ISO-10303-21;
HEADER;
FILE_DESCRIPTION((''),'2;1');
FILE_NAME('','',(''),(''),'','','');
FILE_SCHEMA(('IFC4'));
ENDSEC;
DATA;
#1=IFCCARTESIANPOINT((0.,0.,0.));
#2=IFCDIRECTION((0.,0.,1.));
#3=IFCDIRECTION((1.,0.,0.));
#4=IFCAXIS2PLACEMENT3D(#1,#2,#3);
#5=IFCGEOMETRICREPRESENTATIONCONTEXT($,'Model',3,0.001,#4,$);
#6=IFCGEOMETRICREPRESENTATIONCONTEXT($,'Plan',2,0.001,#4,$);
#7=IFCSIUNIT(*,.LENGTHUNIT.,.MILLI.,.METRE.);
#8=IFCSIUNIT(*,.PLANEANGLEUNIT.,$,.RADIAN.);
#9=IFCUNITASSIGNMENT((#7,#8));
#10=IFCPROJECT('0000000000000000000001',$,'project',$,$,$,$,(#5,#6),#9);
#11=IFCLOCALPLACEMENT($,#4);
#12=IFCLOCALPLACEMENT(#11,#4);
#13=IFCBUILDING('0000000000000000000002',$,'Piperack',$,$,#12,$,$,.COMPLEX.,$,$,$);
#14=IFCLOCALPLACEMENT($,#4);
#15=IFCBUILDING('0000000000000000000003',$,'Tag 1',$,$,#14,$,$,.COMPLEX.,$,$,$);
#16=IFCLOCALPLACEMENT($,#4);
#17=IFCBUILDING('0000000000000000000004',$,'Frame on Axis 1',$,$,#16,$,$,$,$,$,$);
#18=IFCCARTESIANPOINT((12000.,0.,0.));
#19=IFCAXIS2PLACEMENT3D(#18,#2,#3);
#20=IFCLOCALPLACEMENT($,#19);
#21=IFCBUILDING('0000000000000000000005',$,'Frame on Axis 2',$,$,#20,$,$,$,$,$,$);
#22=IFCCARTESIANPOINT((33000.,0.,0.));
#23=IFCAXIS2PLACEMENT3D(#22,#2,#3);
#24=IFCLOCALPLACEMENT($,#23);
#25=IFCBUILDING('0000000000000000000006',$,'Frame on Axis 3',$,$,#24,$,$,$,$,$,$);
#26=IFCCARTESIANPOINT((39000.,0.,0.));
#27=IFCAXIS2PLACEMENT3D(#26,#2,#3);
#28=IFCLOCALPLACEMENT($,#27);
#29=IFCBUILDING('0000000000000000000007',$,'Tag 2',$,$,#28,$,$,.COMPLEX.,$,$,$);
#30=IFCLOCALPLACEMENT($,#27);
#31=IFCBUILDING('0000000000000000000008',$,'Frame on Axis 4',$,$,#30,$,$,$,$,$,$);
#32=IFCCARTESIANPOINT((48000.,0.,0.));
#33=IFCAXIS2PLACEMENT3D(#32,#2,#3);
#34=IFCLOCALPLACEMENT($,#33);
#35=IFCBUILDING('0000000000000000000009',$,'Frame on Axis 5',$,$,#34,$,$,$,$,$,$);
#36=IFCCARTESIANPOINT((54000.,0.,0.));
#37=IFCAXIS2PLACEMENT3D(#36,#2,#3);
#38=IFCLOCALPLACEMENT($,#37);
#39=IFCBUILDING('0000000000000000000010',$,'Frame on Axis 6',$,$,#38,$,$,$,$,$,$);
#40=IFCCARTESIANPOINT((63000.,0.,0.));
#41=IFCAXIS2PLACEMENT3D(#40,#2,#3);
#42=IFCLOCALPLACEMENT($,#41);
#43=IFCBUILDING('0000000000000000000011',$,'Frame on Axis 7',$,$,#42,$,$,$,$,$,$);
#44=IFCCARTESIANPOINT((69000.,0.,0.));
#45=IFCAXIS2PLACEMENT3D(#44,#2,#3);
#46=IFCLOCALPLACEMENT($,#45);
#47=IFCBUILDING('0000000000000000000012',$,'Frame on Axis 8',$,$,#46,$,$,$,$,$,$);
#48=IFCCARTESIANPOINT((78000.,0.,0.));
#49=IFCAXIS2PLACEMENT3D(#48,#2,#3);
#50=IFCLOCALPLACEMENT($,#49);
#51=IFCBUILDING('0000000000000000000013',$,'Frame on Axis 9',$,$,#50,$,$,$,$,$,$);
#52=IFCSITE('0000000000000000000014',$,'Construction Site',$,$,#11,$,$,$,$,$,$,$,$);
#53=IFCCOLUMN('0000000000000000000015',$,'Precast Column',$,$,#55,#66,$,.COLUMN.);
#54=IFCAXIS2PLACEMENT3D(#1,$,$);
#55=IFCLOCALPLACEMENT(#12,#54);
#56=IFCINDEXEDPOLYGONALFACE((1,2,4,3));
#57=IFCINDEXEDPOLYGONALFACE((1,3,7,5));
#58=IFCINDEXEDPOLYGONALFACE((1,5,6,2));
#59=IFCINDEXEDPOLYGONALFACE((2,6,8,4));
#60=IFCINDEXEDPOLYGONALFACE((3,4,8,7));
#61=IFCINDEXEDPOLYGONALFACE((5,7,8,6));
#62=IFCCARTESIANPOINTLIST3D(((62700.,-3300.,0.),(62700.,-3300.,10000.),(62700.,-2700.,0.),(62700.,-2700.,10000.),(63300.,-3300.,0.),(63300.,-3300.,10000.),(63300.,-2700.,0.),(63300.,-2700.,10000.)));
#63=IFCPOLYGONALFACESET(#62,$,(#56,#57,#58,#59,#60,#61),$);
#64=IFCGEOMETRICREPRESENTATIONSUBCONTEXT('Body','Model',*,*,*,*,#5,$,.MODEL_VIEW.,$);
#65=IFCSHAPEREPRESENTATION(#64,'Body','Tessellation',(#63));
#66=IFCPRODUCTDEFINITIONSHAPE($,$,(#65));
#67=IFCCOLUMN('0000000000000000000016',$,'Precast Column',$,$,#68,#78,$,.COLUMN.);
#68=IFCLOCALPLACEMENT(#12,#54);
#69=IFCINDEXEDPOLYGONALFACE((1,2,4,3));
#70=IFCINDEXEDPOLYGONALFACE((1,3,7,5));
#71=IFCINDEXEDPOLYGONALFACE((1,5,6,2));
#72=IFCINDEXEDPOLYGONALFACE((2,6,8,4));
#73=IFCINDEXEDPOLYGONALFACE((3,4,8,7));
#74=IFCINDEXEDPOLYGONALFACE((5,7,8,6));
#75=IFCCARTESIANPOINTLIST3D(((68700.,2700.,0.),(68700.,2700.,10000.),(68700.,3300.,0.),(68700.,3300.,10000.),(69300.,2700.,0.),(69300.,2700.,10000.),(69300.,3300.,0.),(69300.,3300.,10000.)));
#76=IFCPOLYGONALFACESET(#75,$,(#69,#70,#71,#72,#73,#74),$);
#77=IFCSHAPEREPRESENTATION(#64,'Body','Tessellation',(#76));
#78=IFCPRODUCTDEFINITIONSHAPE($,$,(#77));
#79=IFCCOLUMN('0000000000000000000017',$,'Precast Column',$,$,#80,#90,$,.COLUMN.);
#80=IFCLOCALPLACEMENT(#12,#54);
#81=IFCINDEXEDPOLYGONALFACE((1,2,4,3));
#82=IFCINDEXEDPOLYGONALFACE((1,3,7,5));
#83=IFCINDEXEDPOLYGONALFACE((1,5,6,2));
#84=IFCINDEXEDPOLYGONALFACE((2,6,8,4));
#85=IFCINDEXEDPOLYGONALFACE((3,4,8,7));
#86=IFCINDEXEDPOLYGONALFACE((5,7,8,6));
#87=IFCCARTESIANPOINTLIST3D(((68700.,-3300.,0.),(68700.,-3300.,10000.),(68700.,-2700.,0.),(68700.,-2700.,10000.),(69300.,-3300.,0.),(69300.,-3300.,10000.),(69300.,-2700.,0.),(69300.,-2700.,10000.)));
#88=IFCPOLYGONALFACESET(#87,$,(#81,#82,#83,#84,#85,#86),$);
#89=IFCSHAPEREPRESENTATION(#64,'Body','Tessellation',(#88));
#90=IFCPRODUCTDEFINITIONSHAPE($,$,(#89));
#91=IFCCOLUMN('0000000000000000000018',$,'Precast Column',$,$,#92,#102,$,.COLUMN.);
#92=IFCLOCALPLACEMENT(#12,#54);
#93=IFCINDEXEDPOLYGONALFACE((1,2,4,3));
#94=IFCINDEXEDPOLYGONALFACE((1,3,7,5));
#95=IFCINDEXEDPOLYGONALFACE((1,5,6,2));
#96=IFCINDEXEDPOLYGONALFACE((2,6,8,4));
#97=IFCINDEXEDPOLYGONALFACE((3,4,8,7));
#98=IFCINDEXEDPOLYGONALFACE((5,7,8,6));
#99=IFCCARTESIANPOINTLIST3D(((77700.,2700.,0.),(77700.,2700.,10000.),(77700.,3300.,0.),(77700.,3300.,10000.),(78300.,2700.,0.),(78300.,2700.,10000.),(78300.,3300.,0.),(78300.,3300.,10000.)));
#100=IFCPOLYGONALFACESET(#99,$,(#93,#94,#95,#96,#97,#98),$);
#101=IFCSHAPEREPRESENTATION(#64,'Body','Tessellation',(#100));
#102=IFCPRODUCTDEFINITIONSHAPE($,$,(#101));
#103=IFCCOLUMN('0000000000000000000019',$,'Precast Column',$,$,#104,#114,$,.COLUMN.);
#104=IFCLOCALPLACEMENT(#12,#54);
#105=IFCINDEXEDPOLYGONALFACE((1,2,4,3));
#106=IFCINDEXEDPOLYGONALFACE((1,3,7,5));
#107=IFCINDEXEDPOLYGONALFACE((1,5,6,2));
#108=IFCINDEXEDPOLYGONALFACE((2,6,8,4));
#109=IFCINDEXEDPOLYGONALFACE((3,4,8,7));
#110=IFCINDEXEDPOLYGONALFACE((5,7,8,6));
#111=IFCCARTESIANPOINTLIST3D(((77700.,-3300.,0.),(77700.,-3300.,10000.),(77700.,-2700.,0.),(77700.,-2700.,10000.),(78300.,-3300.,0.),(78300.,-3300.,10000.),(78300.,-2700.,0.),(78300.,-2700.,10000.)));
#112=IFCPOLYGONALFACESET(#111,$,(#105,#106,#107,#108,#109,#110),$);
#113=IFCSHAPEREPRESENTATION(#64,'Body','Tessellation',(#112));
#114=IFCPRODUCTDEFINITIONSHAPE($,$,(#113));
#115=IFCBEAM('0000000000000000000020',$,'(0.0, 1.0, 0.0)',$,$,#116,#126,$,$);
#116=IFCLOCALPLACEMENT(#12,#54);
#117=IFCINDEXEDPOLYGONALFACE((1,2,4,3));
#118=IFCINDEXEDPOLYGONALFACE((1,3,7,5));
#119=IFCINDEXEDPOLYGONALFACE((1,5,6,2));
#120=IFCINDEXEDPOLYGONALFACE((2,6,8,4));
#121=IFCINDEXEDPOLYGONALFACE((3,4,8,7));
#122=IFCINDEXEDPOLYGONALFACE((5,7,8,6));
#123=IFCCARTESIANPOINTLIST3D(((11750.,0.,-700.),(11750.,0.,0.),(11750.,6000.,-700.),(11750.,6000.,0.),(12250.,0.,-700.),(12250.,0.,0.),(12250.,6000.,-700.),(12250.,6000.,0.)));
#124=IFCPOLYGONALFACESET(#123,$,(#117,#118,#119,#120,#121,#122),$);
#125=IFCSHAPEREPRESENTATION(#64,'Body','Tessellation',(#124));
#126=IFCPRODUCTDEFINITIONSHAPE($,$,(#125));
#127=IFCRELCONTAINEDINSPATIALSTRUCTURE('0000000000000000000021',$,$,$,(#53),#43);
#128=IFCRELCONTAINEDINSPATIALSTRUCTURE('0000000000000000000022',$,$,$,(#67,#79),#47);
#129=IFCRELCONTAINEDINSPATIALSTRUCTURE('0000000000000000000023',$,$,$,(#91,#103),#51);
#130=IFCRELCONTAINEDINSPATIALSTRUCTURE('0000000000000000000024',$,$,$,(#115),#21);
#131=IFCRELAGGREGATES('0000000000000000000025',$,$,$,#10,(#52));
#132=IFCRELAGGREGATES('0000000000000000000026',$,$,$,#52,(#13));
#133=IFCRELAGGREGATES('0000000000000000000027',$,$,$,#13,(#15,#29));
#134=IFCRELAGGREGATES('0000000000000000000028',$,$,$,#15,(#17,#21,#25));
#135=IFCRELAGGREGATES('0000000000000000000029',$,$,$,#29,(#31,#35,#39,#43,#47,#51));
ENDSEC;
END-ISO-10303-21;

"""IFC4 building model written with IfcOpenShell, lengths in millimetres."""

from ifc_helpers import new_model, si_unit, frame, origin, origin_with_axes, place, context, subcontext, project, spatial, rectangle, extrude, element, save


model = new_model("IFC4")

# Units and contexts
model_context = context("Model", 3, precision=0.001, world=origin_with_axes())
plan_context = context("Plan", 2, precision=0.001, world=origin_with_axes())
body_context = subcontext(model_context, "Body", "Model", "MODEL_VIEW")
ifc_project = project(units=[si_unit("LENGTHUNIT", "METRE", prefix="MILLI"), si_unit("PLANEANGLEUNIT", "RADIAN")], contexts=[model_context, plan_context])

# Site, buildings
site_placement = place(None, origin_with_axes())
site = spatial("IfcSite", under=ifc_project, at=site_placement, Name="Construction Site")
building_1_placement = place(site_placement, origin_with_axes())
building_1 = spatial("IfcBuilding", under=site, at=building_1_placement, Name="Piperack", CompositionType="COMPLEX")
building_2_placement = place(None, origin_with_axes())
building_2 = spatial("IfcBuilding", under=building_1, at=building_2_placement, Name="Tag 1", CompositionType="COMPLEX")
building_3_placement = place(None, origin_with_axes())
building_3 = spatial("IfcBuilding", under=building_2, at=building_3_placement, Name="Frame on Axis 1")

# Shared definitions
building_4_placement = place(None, frame((12000.0, 0.0, 0.0), z_axis=(0.0, 0.0, 1.0), x_axis=(1.0, 0.0, 0.0)))
building_4 = spatial("IfcBuilding", under=building_2, at=building_4_placement, Name="Frame on Axis 2")

# Shared definitions
building_5_placement = place(None, frame((33000.0, 0.0, 0.0), z_axis=(0.0, 0.0, 1.0), x_axis=(1.0, 0.0, 0.0)))
building_5 = spatial("IfcBuilding", under=building_2, at=building_5_placement, Name="Frame on Axis 3")

# Shared definitions
building_6_placement = place(None, frame((39000.0, 0.0, 0.0), z_axis=(0.0, 0.0, 1.0), x_axis=(1.0, 0.0, 0.0)))
building_6 = spatial("IfcBuilding", under=building_1, at=building_6_placement, Name="Tag 2", CompositionType="COMPLEX")
building_7_placement = place(None, frame((39000.0, 0.0, 0.0), z_axis=(0.0, 0.0, 1.0), x_axis=(1.0, 0.0, 0.0)))
building_7 = spatial("IfcBuilding", under=building_6, at=building_7_placement, Name="Frame on Axis 4")

# Shared definitions
building_8_placement = place(None, frame((48000.0, 0.0, 0.0), z_axis=(0.0, 0.0, 1.0), x_axis=(1.0, 0.0, 0.0)))
building_8 = spatial("IfcBuilding", under=building_6, at=building_8_placement, Name="Frame on Axis 5")

# Shared definitions
building_9_placement = place(None, frame((54000.0, 0.0, 0.0), z_axis=(0.0, 0.0, 1.0), x_axis=(1.0, 0.0, 0.0)))
building_9 = spatial("IfcBuilding", under=building_6, at=building_9_placement, Name="Frame on Axis 6")

# Shared definitions
building_10_placement = place(None, frame((63000.0, 0.0, 0.0), z_axis=(0.0, 0.0, 1.0), x_axis=(1.0, 0.0, 0.0)))
building_10 = spatial("IfcBuilding", under=building_6, at=building_10_placement, Name="Frame on Axis 7")

# Column
for number, where, z_axis, name in (
    (1, (0.0, -3000.0, 0.0), (0.0, 0.0, 1.0), "Precast Column"),
):
    element("IfcColumn", number, at=place(building_10_placement, frame(where, z_axis=z_axis)), inside=building_10, Name=name, PredefinedType="COLUMN", context=body_context, shape_type="SweptSolid", body=[
        extrude(rectangle(XDim=600.0, YDim=600.0), origin(), (0.0, 0.0, 1.0), 10000.0),
    ])

# Shared definitions
building_11_placement = place(None, frame((69000.0, 0.0, 0.0), z_axis=(0.0, 0.0, 1.0), x_axis=(1.0, 0.0, 0.0)))
building_11 = spatial("IfcBuilding", under=building_6, at=building_11_placement, Name="Frame on Axis 8")

# Columns
for number, where, z_axis, name in (
    (2, (0.0, 3000.0, 0.0), (0.0, 0.0, 1.0), "Precast Column"),
    (3, (0.0, -3000.0, 0.0), (0.0, 0.0, 1.0), "Precast Column"),
):
    element("IfcColumn", number, at=place(building_11_placement, frame(where, z_axis=z_axis)), inside=building_11, Name=name, PredefinedType="COLUMN", context=body_context, shape_type="SweptSolid", body=[
        extrude(rectangle(XDim=600.0, YDim=600.0), origin(), (0.0, 0.0, 1.0), 10000.0),
    ])

# Shared definitions
building_12_placement = place(None, frame((78000.0, 0.0, 0.0), z_axis=(0.0, 0.0, 1.0), x_axis=(1.0, 0.0, 0.0)))
building_12 = spatial("IfcBuilding", under=building_6, at=building_12_placement, Name="Frame on Axis 9")

# Columns
for number, where, z_axis, name in (
    (4, (0.0, 3000.0, 0.0), (0.0, 0.0, 1.0), "Precast Column"),
    (5, (0.0, -3000.0, 0.0), (0.0, 0.0, 1.0), "Precast Column"),
):
    element("IfcColumn", number, at=place(building_12_placement, frame(where, z_axis=z_axis)), inside=building_12, Name=name, PredefinedType="COLUMN", context=body_context, shape_type="SweptSolid", body=[
        extrude(rectangle(XDim=600.0, YDim=600.0), origin(), (0.0, 0.0, 1.0), 10000.0),
    ])

# Beam
beam_placement = place(building_4_placement, frame((0.0, 0.0, 0.0), z_axis=(0.0, 1.0, 0.0)))
element("IfcBeam", 6, at=beam_placement, inside=building_4, Name="(0.0, 1.0, 0.0)", context=body_context, shape_type="SweptSolid", body=[
    extrude(rectangle(XDim=500.0, YDim=700.0), frame((0.0, 350.0, 0.0)), (0.0, 0.0, 1.0), 6000.0),
])

save(model, "model.ifc")
